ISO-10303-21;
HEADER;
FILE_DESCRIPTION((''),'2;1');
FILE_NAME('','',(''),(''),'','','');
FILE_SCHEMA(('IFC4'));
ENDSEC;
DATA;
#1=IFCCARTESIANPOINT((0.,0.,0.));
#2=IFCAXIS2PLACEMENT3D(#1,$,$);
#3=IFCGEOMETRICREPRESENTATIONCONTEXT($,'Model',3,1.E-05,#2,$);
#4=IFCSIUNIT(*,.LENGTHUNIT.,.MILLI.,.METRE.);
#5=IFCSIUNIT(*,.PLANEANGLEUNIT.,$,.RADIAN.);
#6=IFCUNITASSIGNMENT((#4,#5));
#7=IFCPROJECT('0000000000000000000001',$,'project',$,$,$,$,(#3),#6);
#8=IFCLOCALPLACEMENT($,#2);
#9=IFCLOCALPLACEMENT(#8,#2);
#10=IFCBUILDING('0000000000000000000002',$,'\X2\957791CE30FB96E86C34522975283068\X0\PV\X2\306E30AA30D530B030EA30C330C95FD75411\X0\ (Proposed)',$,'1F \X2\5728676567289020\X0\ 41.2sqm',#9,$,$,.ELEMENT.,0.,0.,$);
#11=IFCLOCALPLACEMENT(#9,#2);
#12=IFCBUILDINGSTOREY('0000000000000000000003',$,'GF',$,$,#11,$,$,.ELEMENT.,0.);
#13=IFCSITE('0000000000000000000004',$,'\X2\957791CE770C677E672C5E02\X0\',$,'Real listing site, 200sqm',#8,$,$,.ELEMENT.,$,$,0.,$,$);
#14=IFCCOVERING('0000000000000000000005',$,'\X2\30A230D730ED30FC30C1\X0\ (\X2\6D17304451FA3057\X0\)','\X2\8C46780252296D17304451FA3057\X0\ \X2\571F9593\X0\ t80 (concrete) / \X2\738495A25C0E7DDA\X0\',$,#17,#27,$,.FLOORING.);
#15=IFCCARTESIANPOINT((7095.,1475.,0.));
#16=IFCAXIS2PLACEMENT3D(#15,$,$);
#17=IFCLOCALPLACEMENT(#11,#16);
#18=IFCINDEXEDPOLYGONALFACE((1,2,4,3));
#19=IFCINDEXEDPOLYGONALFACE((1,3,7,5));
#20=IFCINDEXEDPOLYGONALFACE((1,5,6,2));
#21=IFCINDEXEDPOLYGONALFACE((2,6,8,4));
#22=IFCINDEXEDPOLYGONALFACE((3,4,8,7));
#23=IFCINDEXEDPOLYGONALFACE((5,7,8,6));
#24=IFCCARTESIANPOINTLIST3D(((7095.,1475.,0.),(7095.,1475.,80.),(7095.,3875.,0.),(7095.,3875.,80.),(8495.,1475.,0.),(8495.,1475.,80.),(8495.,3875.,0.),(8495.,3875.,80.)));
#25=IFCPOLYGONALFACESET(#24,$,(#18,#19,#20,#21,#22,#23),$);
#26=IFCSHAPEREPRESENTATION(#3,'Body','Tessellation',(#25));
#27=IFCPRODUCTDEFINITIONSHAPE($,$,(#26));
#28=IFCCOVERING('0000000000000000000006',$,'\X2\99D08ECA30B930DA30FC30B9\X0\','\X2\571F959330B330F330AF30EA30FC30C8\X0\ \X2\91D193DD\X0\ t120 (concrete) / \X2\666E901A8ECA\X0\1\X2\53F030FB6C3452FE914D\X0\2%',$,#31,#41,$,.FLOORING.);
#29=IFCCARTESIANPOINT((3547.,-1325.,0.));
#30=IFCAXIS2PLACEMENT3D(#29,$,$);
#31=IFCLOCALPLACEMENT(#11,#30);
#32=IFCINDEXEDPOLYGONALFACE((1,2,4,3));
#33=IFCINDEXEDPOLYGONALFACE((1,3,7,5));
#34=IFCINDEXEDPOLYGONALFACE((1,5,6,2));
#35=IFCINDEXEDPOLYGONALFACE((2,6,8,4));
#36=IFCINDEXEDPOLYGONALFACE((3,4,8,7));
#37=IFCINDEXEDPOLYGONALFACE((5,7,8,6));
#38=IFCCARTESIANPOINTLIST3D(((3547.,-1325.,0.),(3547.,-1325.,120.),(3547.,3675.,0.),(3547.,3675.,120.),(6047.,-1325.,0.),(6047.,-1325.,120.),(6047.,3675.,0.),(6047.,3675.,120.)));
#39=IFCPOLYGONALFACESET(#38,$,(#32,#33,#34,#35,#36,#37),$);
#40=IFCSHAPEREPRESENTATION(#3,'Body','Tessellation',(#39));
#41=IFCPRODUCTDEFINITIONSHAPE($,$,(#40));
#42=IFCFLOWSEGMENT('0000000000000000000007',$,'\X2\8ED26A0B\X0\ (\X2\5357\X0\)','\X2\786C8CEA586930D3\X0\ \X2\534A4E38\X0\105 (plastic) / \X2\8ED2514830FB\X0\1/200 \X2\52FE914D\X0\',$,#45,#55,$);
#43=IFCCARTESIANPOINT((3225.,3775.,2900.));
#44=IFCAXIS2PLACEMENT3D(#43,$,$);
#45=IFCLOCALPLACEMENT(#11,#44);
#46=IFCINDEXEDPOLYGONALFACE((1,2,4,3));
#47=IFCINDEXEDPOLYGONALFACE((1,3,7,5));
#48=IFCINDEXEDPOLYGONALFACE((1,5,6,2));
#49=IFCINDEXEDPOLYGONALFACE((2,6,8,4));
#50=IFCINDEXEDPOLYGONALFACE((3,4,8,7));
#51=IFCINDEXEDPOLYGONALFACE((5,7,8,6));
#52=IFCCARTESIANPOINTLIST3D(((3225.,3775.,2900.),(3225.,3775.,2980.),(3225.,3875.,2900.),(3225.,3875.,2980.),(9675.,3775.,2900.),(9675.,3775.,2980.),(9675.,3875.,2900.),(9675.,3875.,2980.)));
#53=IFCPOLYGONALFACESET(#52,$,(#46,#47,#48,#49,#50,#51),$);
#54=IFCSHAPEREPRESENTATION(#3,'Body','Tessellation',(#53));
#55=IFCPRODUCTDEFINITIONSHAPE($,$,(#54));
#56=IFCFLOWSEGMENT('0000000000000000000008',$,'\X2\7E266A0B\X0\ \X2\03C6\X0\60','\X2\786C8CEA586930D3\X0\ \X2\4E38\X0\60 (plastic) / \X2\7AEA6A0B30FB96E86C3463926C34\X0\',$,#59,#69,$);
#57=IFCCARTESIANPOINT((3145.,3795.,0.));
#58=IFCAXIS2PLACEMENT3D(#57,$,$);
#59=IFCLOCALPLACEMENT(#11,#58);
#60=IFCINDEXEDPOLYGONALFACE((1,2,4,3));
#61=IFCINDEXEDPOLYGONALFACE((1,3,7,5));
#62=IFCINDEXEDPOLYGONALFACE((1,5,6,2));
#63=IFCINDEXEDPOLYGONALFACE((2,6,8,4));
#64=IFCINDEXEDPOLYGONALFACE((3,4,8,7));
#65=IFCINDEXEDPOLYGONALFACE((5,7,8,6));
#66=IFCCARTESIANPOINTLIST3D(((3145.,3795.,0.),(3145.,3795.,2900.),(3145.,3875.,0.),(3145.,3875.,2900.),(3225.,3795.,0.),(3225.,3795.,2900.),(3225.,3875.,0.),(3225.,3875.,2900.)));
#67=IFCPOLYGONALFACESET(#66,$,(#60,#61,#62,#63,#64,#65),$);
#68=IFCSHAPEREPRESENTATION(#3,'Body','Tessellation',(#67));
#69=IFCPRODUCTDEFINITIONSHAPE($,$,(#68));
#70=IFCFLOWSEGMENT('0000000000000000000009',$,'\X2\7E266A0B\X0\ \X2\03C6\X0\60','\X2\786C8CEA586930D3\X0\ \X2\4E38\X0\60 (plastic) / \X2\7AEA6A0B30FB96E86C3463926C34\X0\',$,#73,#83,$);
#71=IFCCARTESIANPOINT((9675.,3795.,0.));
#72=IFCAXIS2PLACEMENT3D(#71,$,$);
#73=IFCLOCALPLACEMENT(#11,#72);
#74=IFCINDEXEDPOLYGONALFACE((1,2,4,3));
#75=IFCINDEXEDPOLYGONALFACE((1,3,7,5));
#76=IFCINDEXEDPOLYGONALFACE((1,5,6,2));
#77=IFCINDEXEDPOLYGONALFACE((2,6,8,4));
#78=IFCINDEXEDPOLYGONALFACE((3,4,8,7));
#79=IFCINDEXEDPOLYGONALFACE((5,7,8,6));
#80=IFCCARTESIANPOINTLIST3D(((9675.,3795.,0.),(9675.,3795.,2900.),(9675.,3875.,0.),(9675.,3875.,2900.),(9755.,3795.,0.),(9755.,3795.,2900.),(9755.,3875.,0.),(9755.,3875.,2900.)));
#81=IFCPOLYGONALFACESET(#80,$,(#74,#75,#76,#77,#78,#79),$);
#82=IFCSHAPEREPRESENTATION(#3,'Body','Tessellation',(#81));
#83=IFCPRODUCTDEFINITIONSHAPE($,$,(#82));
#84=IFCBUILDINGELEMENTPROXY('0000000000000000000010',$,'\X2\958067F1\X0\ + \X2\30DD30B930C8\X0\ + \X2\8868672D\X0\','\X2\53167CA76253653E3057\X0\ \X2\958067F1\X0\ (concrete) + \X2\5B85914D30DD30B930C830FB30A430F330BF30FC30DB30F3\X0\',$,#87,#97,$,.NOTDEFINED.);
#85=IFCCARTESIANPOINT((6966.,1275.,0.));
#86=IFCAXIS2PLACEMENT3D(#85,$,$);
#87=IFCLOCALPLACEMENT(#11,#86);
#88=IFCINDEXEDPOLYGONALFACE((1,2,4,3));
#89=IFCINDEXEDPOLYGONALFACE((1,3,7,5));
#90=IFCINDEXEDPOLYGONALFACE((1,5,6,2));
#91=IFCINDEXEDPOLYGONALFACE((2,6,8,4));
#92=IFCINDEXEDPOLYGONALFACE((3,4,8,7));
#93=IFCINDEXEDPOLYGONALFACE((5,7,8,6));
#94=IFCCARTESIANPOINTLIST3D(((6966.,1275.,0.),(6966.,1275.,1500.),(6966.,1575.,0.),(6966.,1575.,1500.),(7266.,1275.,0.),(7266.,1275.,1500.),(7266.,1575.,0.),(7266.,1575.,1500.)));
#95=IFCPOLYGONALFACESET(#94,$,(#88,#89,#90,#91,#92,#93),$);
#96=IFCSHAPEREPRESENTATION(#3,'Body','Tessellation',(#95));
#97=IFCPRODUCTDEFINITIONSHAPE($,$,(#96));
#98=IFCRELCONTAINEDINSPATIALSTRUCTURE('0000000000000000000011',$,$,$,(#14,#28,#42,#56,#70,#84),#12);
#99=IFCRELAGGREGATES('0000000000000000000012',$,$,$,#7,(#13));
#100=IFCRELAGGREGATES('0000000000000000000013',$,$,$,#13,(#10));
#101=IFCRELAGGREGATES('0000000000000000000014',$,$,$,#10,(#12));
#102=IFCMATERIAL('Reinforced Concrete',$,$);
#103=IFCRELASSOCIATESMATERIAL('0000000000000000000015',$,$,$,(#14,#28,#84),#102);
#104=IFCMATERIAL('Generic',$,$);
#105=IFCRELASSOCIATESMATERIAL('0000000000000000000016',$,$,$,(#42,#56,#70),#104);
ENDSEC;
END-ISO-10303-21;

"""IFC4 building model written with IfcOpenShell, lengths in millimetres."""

from ifc_helpers import new_model, si_unit, frame, frame_2d, origin, place, context, project, spatial, rectangle, extrude, material, element, save


model = new_model("IFC4")

# Units and contexts
model_context = context("Model", 3, precision=1e-05, world=origin())
ifc_project = project(units=[si_unit("LENGTHUNIT", "METRE", prefix="MILLI"), si_unit("PLANEANGLEUNIT", "RADIAN")], contexts=[model_context])

# Site, building, storey
site_placement = place(None, origin())
site = spatial("IfcSite", under=ifc_project, at=site_placement, Name="長野県松本市", ObjectType="Real listing site, 200sqm", CompositionType="ELEMENT", RefElevation=0.0)
building_placement = place(site_placement, origin())
building = spatial("IfcBuilding", under=site, at=building_placement, Name="長野・雨水利用とPVのオフグリッド志向 (Proposed)", ObjectType="1F 在来木造 41.2sqm", CompositionType="ELEMENT", ElevationOfRefHeight=0.0, ElevationOfTerrain=0.0)
storey_placement = place(building_placement, origin())
storey = spatial("IfcBuildingStorey", under=building, at=storey_placement, Name="GF", CompositionType="ELEMENT", Elevation=0.0)

# Shared definitions
ifc_material_1 = material(Name="Reinforced Concrete")

# Coverings
ifc_material_2 = material(Name="Generic")
covering_1_placement = place(storey_placement, frame((7095.0, 1475.0, 0.0)))
element("IfcCovering", 1, at=covering_1_placement, inside=storey, material=ifc_material_1, Name="アプローチ (洗い出し)", Description="豆砂利洗い出し 土間 t80 (concrete) / 玄関導線", PredefinedType="FLOORING", context=model_context, shape_type="SweptSolid", body=[
    extrude(rectangle(XDim=1400.0, YDim=2400.0, at=frame_2d((700.0, 1200.0))), frame((7095.0, 1475.0, 0.0)), (0.0, 0.0, 1.0), 80.0),
])
covering_2_placement = place(storey_placement, frame((3547.0, -1325.0, 0.0)))
element("IfcCovering", 2, at=covering_2_placement, inside=storey, material=ifc_material_1, Name="駐車スペース", Description="土間コンクリート 金鏝 t120 (concrete) / 普通車1台・水勾配2%", PredefinedType="FLOORING", context=model_context, shape_type="SweptSolid", body=[
    extrude(rectangle(XDim=2500.0, YDim=5000.0, at=frame_2d((1250.0, 2500.0))), frame((3547.0, -1325.0, 0.0)), (0.0, 0.0, 1.0), 120.0),
])

# Flow segments
flow_segment_1_placement = place(storey_placement, frame((3225.0, 3775.0, 2900.0)))
element("IfcFlowSegment", 3, at=flow_segment_1_placement, inside=storey, material=ifc_material_2, Name="軒樋 (南)", Description="硬質塩ビ 半丸105 (plastic) / 軒先・1/200 勾配", context=model_context, shape_type="SweptSolid", body=[
    extrude(rectangle(XDim=6450.0, YDim=100.0, at=frame_2d((3225.0, 50.0))), frame((3225.0, 3775.0, 2900.0)), (0.0, 0.0, 1.0), 80.0),
])
flow_segment_2_placement = place(storey_placement, frame((3145.0, 3795.0, 0.0)))
element("IfcFlowSegment", 4, at=flow_segment_2_placement, inside=storey, material=ifc_material_2, Name="縦樋 φ60", Description="硬質塩ビ 丸60 (plastic) / 竪樋・雨水排水", context=model_context, shape_type="SweptSolid", body=[
    extrude(rectangle(XDim=80.0, YDim=80.0, at=frame_2d((40.0, 40.0))), frame((3145.0, 3795.0, 0.0)), (0.0, 0.0, 1.0), 2900.0),
])
flow_segment_3_placement = place(storey_placement, frame((9675.0, 3795.0, 0.0)))
element("IfcFlowSegment", 5, at=flow_segment_3_placement, inside=storey, material=ifc_material_2, Name="縦樋 φ60", Description="硬質塩ビ 丸60 (plastic) / 竪樋・雨水排水", context=model_context, shape_type="SweptSolid", body=[
    extrude(rectangle(XDim=80.0, YDim=80.0, at=frame_2d((40.0, 40.0))), frame((9675.0, 3795.0, 0.0)), (0.0, 0.0, 1.0), 2900.0),
])

# Building element proxy
proxy_placement = place(storey_placement, frame((6966.0, 1275.0, 0.0)))
element("IfcBuildingElementProxy", 6, at=proxy_placement, inside=storey, material=ifc_material_1, Name="門柱 + ポスト + 表札", Description="化粧打放し 門柱 (concrete) + 宅配ポスト・インターホン", PredefinedType="NOTDEFINED", context=model_context, shape_type="SweptSolid", body=[
    extrude(rectangle(XDim=300.0, YDim=300.0, at=frame_2d((150.0, 150.0))), frame((6966.0, 1275.0, 0.0)), (0.0, 0.0, 1.0), 1500.0),
])

save(model, "model.ifc")
